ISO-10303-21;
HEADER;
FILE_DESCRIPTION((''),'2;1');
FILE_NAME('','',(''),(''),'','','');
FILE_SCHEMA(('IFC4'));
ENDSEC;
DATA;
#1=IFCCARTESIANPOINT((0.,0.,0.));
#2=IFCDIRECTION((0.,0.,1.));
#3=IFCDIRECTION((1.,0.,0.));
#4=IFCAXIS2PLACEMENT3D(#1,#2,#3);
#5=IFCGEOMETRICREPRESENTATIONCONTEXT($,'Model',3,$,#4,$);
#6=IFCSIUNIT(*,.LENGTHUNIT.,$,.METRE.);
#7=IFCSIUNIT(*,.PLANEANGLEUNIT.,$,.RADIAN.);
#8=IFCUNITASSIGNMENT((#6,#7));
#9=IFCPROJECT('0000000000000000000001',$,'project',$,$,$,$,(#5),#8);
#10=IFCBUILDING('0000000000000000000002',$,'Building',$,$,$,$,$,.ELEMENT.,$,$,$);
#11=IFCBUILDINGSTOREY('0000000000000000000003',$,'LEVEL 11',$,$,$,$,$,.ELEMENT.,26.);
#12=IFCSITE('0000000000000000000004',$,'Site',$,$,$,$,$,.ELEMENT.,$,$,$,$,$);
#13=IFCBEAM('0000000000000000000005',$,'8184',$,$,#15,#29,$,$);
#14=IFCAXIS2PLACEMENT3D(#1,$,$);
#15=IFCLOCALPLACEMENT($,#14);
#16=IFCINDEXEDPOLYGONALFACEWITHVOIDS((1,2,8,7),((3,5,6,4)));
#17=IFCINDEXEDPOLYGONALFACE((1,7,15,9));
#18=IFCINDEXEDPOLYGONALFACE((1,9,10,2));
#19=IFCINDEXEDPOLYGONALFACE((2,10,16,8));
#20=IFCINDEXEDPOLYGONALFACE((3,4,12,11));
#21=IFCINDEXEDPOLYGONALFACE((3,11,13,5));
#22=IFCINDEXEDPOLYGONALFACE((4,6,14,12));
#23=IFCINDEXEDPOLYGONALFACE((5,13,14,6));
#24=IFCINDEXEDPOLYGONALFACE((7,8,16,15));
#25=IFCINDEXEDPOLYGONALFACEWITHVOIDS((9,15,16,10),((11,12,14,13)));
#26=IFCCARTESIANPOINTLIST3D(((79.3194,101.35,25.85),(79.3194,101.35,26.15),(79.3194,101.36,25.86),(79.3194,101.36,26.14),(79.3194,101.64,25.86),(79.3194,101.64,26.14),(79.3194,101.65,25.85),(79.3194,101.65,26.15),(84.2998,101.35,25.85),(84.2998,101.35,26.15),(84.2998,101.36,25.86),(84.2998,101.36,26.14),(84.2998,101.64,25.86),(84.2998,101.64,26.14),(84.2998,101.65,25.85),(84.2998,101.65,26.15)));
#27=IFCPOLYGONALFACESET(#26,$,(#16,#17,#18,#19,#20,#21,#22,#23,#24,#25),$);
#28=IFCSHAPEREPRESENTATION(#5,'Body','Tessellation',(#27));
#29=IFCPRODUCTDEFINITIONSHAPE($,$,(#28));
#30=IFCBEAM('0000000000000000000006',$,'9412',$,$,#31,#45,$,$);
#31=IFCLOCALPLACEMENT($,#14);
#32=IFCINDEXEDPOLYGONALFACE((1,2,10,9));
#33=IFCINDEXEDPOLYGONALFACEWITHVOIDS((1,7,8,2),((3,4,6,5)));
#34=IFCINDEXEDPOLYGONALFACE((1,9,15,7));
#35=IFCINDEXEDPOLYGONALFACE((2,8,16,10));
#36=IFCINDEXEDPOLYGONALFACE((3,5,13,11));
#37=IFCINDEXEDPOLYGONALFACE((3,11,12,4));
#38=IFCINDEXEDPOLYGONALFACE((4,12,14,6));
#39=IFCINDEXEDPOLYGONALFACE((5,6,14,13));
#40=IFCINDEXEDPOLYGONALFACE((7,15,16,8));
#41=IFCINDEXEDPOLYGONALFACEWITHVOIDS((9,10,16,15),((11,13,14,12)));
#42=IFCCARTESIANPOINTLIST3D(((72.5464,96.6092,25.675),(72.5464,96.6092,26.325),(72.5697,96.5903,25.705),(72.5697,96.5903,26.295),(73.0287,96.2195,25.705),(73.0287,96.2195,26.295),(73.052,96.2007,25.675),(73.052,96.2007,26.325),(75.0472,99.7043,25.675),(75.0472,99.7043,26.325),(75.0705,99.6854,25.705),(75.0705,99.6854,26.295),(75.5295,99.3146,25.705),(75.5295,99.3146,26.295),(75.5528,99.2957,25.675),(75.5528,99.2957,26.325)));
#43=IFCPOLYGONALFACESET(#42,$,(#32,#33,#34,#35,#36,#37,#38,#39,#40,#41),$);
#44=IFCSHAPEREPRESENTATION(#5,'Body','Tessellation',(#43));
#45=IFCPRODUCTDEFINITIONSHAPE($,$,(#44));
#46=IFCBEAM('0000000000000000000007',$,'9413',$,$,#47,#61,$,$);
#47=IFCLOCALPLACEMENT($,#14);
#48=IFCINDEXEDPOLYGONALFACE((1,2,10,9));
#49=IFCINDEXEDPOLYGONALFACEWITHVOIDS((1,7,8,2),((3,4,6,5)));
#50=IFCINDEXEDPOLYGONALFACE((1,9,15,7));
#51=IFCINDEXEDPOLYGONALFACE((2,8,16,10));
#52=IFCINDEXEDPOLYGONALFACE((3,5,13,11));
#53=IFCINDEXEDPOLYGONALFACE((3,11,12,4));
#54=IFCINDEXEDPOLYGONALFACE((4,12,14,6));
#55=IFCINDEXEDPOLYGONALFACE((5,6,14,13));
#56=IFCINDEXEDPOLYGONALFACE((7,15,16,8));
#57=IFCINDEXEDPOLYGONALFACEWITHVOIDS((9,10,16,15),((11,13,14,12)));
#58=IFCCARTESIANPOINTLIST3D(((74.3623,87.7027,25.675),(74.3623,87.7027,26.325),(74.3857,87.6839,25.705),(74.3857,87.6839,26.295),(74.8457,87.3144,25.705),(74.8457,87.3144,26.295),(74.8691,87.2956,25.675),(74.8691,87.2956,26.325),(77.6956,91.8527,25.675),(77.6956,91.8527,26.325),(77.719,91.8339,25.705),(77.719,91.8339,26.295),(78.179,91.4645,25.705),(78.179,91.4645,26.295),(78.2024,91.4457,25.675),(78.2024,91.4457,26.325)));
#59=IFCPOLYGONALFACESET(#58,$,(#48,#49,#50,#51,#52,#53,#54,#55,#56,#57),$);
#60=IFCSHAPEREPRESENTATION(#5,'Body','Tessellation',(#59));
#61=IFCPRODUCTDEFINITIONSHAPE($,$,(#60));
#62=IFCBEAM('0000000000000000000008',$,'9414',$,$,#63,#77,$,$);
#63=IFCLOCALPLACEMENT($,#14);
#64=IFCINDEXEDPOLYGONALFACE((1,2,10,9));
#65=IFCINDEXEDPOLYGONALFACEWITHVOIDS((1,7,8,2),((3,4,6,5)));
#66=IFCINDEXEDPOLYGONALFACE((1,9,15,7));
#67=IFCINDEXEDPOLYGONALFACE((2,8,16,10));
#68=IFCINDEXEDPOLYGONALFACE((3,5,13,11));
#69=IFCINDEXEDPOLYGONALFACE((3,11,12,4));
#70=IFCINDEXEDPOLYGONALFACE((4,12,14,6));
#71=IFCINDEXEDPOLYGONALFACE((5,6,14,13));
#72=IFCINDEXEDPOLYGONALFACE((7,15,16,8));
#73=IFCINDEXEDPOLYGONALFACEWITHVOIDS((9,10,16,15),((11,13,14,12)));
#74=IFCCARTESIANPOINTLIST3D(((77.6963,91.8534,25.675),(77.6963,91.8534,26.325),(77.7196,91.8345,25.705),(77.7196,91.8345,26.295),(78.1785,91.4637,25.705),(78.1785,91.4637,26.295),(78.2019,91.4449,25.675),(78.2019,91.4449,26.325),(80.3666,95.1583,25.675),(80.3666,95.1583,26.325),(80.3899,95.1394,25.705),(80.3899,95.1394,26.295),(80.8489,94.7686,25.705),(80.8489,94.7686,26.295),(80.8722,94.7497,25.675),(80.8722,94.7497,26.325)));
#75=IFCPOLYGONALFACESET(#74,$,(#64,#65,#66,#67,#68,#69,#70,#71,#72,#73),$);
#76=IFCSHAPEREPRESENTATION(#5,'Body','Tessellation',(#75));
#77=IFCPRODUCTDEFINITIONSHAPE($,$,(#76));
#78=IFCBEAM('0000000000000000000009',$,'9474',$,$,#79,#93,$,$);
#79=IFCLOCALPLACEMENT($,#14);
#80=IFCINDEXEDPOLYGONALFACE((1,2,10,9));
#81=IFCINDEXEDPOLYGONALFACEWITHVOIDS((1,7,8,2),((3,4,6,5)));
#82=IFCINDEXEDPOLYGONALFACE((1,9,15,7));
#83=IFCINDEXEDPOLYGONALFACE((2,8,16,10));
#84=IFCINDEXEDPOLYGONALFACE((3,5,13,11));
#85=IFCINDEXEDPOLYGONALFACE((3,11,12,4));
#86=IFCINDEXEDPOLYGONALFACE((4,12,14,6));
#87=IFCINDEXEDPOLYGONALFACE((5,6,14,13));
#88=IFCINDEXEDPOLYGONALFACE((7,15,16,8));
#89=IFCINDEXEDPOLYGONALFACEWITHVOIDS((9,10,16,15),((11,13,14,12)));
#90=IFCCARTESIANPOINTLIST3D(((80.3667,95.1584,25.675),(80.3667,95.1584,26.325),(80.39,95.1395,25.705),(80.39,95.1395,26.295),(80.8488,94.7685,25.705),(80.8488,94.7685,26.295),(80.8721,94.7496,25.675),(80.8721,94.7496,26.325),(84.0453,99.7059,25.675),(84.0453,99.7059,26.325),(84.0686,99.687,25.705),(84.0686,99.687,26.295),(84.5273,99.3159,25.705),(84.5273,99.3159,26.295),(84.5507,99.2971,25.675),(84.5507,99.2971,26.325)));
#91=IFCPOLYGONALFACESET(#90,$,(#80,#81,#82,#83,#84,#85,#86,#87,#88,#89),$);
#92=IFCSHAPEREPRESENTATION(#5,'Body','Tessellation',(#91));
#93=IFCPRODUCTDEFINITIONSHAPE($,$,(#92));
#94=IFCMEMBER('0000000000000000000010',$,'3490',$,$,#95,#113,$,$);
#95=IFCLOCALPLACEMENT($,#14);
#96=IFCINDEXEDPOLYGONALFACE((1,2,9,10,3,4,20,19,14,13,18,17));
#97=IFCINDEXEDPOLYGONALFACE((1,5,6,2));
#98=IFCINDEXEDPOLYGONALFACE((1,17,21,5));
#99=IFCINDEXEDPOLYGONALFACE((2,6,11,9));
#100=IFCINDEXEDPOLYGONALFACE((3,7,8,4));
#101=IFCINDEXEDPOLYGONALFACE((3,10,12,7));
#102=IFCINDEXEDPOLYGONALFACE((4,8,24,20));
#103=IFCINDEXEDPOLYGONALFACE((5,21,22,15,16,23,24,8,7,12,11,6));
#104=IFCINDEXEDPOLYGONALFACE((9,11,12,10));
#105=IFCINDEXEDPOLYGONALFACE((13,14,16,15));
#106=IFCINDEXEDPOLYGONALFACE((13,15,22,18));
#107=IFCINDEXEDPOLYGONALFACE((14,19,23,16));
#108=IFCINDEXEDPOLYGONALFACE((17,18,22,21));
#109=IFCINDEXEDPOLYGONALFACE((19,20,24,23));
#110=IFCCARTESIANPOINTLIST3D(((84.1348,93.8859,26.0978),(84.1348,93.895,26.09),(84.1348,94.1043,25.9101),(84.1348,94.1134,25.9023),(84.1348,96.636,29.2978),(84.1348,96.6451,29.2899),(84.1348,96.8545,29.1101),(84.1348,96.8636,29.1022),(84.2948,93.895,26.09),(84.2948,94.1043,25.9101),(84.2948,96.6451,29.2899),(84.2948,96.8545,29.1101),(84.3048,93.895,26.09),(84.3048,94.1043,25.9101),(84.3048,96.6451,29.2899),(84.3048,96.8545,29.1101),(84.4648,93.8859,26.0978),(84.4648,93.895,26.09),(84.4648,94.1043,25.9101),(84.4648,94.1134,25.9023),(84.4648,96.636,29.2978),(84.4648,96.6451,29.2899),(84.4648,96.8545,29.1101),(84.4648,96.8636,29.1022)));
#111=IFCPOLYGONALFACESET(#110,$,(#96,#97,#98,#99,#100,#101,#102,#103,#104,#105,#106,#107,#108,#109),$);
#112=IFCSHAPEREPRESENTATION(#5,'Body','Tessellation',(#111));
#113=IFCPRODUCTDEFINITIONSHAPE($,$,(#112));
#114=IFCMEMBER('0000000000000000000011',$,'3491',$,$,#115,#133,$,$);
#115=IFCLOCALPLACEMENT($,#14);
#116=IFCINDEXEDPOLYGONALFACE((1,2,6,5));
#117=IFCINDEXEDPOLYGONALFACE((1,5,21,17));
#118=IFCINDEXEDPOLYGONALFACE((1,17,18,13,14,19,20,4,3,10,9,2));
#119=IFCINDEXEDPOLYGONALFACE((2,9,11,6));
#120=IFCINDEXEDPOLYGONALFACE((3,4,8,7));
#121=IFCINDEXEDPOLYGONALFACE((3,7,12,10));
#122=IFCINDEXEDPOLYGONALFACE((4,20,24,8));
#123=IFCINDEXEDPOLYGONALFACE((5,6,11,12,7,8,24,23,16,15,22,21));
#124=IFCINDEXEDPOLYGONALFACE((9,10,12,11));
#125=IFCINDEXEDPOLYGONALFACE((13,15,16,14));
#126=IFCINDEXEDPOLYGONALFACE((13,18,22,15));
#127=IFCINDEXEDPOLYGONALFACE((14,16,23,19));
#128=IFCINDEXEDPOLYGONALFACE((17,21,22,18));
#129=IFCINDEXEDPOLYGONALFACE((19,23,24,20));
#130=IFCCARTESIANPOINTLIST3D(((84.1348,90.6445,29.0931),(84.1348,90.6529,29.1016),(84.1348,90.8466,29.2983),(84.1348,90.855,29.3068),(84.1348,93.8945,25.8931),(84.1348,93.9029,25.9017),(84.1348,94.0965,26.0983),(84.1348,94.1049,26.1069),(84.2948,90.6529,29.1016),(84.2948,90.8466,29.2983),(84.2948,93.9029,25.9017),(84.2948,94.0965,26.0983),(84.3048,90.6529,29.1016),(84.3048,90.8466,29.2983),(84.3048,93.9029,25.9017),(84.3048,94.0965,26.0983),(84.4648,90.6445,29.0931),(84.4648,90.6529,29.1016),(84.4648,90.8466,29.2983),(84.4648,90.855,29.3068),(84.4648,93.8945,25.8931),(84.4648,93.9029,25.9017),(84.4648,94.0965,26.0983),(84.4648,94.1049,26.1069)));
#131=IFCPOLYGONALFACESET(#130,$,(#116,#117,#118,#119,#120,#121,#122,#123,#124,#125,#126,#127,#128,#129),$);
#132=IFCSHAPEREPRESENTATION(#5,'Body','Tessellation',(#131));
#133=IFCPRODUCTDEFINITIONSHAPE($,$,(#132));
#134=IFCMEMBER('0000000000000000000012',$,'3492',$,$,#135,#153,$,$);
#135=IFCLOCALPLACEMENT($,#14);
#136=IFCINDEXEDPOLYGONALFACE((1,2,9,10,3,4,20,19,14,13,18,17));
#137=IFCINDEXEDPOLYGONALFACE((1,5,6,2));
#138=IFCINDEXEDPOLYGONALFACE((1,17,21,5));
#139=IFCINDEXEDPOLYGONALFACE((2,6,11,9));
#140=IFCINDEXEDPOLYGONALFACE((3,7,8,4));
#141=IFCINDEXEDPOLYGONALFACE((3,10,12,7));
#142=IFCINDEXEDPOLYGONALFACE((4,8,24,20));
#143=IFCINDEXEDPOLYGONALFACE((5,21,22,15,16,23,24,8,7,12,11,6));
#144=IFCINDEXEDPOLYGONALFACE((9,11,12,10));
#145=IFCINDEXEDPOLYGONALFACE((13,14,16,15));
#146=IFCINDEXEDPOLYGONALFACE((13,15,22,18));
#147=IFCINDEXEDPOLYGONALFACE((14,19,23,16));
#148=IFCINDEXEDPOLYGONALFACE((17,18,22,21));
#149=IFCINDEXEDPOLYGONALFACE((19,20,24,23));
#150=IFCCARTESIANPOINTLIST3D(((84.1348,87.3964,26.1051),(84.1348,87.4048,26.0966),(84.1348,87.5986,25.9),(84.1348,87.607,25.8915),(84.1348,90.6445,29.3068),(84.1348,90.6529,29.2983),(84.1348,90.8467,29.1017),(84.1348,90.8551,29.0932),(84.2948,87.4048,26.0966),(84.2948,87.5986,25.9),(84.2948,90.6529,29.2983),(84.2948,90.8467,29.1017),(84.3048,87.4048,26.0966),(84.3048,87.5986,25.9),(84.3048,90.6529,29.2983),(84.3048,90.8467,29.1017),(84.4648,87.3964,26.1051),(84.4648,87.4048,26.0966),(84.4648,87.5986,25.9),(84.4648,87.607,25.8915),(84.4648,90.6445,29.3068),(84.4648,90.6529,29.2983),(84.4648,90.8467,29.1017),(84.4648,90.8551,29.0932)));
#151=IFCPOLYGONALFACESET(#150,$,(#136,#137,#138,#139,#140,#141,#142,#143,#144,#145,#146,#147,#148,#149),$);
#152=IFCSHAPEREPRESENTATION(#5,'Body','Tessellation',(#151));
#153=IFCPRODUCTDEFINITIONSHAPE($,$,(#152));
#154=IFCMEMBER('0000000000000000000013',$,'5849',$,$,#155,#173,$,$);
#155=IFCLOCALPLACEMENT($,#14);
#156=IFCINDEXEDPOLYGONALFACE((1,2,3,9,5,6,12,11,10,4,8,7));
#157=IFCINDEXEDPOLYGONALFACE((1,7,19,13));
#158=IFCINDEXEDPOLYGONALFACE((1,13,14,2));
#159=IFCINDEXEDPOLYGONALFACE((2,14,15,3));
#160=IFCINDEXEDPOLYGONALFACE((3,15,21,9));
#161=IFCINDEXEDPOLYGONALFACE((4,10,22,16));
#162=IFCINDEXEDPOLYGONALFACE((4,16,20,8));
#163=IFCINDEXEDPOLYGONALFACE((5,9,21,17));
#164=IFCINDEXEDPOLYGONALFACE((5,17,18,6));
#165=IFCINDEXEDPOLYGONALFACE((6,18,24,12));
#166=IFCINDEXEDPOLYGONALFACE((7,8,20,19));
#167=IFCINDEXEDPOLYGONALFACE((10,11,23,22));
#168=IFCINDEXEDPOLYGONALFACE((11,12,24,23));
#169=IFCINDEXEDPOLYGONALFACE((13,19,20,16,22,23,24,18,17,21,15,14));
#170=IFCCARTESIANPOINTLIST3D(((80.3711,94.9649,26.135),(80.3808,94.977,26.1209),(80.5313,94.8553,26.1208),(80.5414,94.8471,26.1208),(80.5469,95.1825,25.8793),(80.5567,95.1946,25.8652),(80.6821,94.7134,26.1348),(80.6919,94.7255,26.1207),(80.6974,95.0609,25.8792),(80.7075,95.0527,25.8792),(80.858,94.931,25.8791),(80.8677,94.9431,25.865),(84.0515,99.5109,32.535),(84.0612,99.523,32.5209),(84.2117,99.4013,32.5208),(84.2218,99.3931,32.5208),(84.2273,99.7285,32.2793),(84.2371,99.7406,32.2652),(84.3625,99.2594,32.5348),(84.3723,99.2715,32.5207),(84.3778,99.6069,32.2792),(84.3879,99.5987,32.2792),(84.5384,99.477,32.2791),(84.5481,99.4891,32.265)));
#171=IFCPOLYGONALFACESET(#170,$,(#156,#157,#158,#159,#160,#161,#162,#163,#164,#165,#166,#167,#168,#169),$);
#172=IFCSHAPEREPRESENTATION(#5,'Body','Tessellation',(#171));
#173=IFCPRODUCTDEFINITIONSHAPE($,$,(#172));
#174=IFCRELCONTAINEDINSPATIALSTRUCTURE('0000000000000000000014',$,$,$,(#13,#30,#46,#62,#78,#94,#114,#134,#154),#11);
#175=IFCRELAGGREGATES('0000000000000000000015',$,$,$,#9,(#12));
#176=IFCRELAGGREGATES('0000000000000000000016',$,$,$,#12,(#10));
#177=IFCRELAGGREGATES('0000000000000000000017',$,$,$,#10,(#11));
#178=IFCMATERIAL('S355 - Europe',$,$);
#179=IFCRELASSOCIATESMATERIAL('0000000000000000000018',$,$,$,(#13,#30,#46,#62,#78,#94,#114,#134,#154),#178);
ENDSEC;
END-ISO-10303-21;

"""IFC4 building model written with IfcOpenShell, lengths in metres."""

from ifc_helpers import new_model, si_unit, frame, origin_with_axes, origin_2d_with_axis, place, context, project, spatial, hollow_rectangle, i_section, extrude, material, material_profile, profile_set, profile_usage, element, save


model = new_model("IFC4")

# Units and contexts
model_context = context("Model", 3, world=origin_with_axes())
ifc_project = project(units=[si_unit("LENGTHUNIT", "METRE"), si_unit("PLANEANGLEUNIT", "RADIAN")], contexts=[model_context])

# Site, building, storey
site = spatial("IfcSite", under=ifc_project, Name="Site", CompositionType="ELEMENT")
building = spatial("IfcBuilding", under=site, Name="Building", CompositionType="ELEMENT")
storey = spatial("IfcBuildingStorey", under=building, Name="LEVEL 11", CompositionType="ELEMENT", Elevation=26.0)

# Shared definitions
ifc_material = material(Name="S355 - Europe")

# Beams
ifc_material_profile_1 = material_profile(ifc_material, hollow_rectangle(XDim=0.3, YDim=0.3, WallThickness=0.01, at=origin_2d_with_axis()))
ifc_profile_set_1 = profile_set([ifc_material_profile_1])
ifc_profile_usage_1 = profile_usage(ifc_profile_set_1, cardinal=10)
beam_1_placement = place(None, frame((79.3194, 101.5, 26.0), z_axis=(1.0, 0.0, 0.0), x_axis=(0.0, 1.0, 0.0)))
element("IfcBeam", 1, at=beam_1_placement, inside=storey, material=ifc_profile_usage_1, Name="8184", context=model_context, shape_type="SweptSolid", body=[
    extrude(hollow_rectangle(XDim=0.3, YDim=0.3, WallThickness=0.01, at=origin_2d_with_axis()), origin_with_axes(), (0.0, 0.0, 1.0), 4.9804),
])
ifc_material_profile_2 = material_profile(ifc_material, hollow_rectangle(XDim=0.65, YDim=0.65, WallThickness=0.03, at=origin_2d_with_axis()))
ifc_profile_set_2 = profile_set([ifc_material_profile_2])
ifc_profile_usage_2 = profile_usage(ifc_profile_set_2, cardinal=10)
beam_2_placement = place(None, frame((75.3, 99.5, 26.0), z_axis=(-0.62848, -0.777826, 0.0), x_axis=(0.777711, -0.628621, 0.0)))
element("IfcBeam", 2, at=beam_2_placement, inside=storey, material=ifc_profile_usage_2, Name="9412", context=model_context, shape_type="SweptSolid", body=[
    extrude(hollow_rectangle(XDim=0.65, YDim=0.65, WallThickness=0.03, at=origin_2d_with_axis()), origin_with_axes(), (0.0, 0.0, 1.0), 3.9791),
])
ifc_material_profile_3 = material_profile(ifc_material, hollow_rectangle(XDim=0.65, YDim=0.65, WallThickness=0.03, at=origin_2d_with_axis()))
ifc_profile_set_3 = profile_set([ifc_material_profile_3])
ifc_profile_usage_3 = profile_usage(ifc_profile_set_3, cardinal=10)
beam_3_placement = place(None, frame((77.949, 91.6492, 26.0), z_axis=(-0.626214, -0.779651, 0.0), x_axis=(0.779489, -0.626416, 0.0)))
element("IfcBeam", 3, at=beam_3_placement, inside=storey, material=ifc_profile_usage_3, Name="9413", context=model_context, shape_type="SweptSolid", body=[
    extrude(hollow_rectangle(XDim=0.65, YDim=0.65, WallThickness=0.03, at=origin_2d_with_axis()), origin_with_axes(), (0.0, 0.0, 1.0), 5.323),
])
ifc_material_profile_4 = material_profile(ifc_material, hollow_rectangle(XDim=0.65, YDim=0.65, WallThickness=0.03, at=origin_2d_with_axis()))
ifc_profile_set_4 = profile_set([ifc_material_profile_4])
ifc_profile_usage_4 = profile_usage(ifc_profile_set_4, cardinal=10)
beam_4_placement = place(None, frame((80.6194, 94.954, 26.0), z_axis=(-0.62848, -0.777826, 0.0), x_axis=(0.777711, -0.628621, 0.0)))
element("IfcBeam", 4, at=beam_4_placement, inside=storey, material=ifc_profile_usage_4, Name="9414", context=model_context, shape_type="SweptSolid", body=[
    extrude(hollow_rectangle(XDim=0.65, YDim=0.65, WallThickness=0.03, at=origin_2d_with_axis()), origin_with_axes(), (0.0, 0.0, 1.0), 4.2489),
])
ifc_material_profile_5 = material_profile(ifc_material, hollow_rectangle(XDim=0.65, YDim=0.65, WallThickness=0.03, at=origin_2d_with_axis()))
ifc_profile_set_5 = profile_set([ifc_material_profile_5])
ifc_profile_usage_5 = profile_usage(ifc_profile_set_5, cardinal=10)
beam_5_placement = place(None, frame((80.6194, 94.954, 26.0), z_axis=(0.62892, 0.77747, 0.0), x_axis=(-0.777826, 0.62848, 0.0)))
element("IfcBeam", 5, at=beam_5_placement, inside=storey, material=ifc_profile_usage_5, Name="9474", context=model_context, shape_type="SweptSolid", body=[
    extrude(hollow_rectangle(XDim=0.65, YDim=0.65, WallThickness=0.03, at=origin_2d_with_axis()), origin_with_axes(), (0.0, 0.0, 1.0), 5.8491),
])

# Members
ifc_material_profile_6 = material_profile(ifc_material, i_section(OverallWidth=0.33, OverallDepth=0.3, WebThickness=0.01, FlangeThickness=0.012, at=origin_2d_with_axis()))
ifc_profile_set_6 = profile_set([ifc_material_profile_6])
ifc_profile_usage_6 = profile_usage(ifc_profile_set_6, cardinal=10)
member_1_placement = place(None, frame((84.2998, 96.7498, 29.2), z_axis=(0.0, -0.651794, -0.758396), x_axis=(1.0, 0.0, 0.0)))
element("IfcMember", 6, at=member_1_placement, inside=storey, material=ifc_profile_usage_6, Name="3490", context=model_context, shape_type="SweptSolid", body=[
    extrude(i_section(OverallWidth=0.33, OverallDepth=0.3, WebThickness=0.01, FlangeThickness=0.012, at=origin_2d_with_axis()), origin_with_axes(), (0.0, 0.0, 1.0), 4.2194),
])
ifc_material_profile_7 = material_profile(ifc_material, i_section(OverallWidth=0.33, OverallDepth=0.3, WebThickness=0.01, FlangeThickness=0.012, at=origin_2d_with_axis()))
ifc_profile_set_7 = profile_set([ifc_material_profile_7])
ifc_profile_usage_7 = profile_usage(ifc_profile_set_7, cardinal=10)
member_2_placement = place(None, frame((84.2998, 93.9997, 26.0), z_axis=(0.0, -0.712567, 0.701604), x_axis=(1.0, 0.0, 0.0)))
element("IfcMember", 7, at=member_2_placement, inside=storey, material=ifc_profile_usage_7, Name="3491", context=model_context, shape_type="SweptSolid", body=[
    extrude(i_section(OverallWidth=0.33, OverallDepth=0.3, WebThickness=0.01, FlangeThickness=0.012, at=origin_2d_with_axis()), origin_with_axes(), (0.0, 0.0, 1.0), 4.5609),
])
ifc_material_profile_8 = material_profile(ifc_material, i_section(OverallWidth=0.33, OverallDepth=0.3, WebThickness=0.01, FlangeThickness=0.012, at=origin_2d_with_axis()))
ifc_profile_set_8 = profile_set([ifc_material_profile_8])
ifc_profile_usage_8 = profile_usage(ifc_profile_set_8, cardinal=10)
member_3_placement = place(None, frame((84.2998, 90.7498, 29.2), z_axis=(0.0, -0.712178, -0.701999), x_axis=(1.0, 0.0, 0.0)))
element("IfcMember", 8, at=member_3_placement, inside=storey, material=ifc_profile_usage_8, Name="3492", context=model_context, shape_type="SweptSolid", body=[
    extrude(i_section(OverallWidth=0.33, OverallDepth=0.3, WebThickness=0.01, FlangeThickness=0.012, at=origin_2d_with_axis()), origin_with_axes(), (0.0, 0.0, 1.0), 4.5608),
])
ifc_material_profile_9 = material_profile(ifc_material, i_section(OverallWidth=0.4, OverallDepth=0.4, WebThickness=0.013, FlangeThickness=0.021, at=origin_2d_with_axis()))
ifc_profile_set_9 = profile_set([ifc_material_profile_9])
ifc_profile_usage_9 = profile_usage(ifc_profile_set_9, cardinal=10)
member_4_placement = place(None, frame((80.6194, 94.954, 26.0), z_axis=(0.424491, 0.524328, 0.738165), x_axis=(-0.777826, 0.62848, 0.0)))
element("IfcMember", 9, at=member_4_placement, inside=storey, material=ifc_profile_usage_9, Name="5849", context=model_context, shape_type="SweptSolid", body=[
    extrude(i_section(OverallWidth=0.4, OverallDepth=0.4, WebThickness=0.013, FlangeThickness=0.021, at=origin_2d_with_axis()), origin_with_axes(), (0.0, 0.0, 1.0), 8.6701),
])

save(model, "model.ifc")
